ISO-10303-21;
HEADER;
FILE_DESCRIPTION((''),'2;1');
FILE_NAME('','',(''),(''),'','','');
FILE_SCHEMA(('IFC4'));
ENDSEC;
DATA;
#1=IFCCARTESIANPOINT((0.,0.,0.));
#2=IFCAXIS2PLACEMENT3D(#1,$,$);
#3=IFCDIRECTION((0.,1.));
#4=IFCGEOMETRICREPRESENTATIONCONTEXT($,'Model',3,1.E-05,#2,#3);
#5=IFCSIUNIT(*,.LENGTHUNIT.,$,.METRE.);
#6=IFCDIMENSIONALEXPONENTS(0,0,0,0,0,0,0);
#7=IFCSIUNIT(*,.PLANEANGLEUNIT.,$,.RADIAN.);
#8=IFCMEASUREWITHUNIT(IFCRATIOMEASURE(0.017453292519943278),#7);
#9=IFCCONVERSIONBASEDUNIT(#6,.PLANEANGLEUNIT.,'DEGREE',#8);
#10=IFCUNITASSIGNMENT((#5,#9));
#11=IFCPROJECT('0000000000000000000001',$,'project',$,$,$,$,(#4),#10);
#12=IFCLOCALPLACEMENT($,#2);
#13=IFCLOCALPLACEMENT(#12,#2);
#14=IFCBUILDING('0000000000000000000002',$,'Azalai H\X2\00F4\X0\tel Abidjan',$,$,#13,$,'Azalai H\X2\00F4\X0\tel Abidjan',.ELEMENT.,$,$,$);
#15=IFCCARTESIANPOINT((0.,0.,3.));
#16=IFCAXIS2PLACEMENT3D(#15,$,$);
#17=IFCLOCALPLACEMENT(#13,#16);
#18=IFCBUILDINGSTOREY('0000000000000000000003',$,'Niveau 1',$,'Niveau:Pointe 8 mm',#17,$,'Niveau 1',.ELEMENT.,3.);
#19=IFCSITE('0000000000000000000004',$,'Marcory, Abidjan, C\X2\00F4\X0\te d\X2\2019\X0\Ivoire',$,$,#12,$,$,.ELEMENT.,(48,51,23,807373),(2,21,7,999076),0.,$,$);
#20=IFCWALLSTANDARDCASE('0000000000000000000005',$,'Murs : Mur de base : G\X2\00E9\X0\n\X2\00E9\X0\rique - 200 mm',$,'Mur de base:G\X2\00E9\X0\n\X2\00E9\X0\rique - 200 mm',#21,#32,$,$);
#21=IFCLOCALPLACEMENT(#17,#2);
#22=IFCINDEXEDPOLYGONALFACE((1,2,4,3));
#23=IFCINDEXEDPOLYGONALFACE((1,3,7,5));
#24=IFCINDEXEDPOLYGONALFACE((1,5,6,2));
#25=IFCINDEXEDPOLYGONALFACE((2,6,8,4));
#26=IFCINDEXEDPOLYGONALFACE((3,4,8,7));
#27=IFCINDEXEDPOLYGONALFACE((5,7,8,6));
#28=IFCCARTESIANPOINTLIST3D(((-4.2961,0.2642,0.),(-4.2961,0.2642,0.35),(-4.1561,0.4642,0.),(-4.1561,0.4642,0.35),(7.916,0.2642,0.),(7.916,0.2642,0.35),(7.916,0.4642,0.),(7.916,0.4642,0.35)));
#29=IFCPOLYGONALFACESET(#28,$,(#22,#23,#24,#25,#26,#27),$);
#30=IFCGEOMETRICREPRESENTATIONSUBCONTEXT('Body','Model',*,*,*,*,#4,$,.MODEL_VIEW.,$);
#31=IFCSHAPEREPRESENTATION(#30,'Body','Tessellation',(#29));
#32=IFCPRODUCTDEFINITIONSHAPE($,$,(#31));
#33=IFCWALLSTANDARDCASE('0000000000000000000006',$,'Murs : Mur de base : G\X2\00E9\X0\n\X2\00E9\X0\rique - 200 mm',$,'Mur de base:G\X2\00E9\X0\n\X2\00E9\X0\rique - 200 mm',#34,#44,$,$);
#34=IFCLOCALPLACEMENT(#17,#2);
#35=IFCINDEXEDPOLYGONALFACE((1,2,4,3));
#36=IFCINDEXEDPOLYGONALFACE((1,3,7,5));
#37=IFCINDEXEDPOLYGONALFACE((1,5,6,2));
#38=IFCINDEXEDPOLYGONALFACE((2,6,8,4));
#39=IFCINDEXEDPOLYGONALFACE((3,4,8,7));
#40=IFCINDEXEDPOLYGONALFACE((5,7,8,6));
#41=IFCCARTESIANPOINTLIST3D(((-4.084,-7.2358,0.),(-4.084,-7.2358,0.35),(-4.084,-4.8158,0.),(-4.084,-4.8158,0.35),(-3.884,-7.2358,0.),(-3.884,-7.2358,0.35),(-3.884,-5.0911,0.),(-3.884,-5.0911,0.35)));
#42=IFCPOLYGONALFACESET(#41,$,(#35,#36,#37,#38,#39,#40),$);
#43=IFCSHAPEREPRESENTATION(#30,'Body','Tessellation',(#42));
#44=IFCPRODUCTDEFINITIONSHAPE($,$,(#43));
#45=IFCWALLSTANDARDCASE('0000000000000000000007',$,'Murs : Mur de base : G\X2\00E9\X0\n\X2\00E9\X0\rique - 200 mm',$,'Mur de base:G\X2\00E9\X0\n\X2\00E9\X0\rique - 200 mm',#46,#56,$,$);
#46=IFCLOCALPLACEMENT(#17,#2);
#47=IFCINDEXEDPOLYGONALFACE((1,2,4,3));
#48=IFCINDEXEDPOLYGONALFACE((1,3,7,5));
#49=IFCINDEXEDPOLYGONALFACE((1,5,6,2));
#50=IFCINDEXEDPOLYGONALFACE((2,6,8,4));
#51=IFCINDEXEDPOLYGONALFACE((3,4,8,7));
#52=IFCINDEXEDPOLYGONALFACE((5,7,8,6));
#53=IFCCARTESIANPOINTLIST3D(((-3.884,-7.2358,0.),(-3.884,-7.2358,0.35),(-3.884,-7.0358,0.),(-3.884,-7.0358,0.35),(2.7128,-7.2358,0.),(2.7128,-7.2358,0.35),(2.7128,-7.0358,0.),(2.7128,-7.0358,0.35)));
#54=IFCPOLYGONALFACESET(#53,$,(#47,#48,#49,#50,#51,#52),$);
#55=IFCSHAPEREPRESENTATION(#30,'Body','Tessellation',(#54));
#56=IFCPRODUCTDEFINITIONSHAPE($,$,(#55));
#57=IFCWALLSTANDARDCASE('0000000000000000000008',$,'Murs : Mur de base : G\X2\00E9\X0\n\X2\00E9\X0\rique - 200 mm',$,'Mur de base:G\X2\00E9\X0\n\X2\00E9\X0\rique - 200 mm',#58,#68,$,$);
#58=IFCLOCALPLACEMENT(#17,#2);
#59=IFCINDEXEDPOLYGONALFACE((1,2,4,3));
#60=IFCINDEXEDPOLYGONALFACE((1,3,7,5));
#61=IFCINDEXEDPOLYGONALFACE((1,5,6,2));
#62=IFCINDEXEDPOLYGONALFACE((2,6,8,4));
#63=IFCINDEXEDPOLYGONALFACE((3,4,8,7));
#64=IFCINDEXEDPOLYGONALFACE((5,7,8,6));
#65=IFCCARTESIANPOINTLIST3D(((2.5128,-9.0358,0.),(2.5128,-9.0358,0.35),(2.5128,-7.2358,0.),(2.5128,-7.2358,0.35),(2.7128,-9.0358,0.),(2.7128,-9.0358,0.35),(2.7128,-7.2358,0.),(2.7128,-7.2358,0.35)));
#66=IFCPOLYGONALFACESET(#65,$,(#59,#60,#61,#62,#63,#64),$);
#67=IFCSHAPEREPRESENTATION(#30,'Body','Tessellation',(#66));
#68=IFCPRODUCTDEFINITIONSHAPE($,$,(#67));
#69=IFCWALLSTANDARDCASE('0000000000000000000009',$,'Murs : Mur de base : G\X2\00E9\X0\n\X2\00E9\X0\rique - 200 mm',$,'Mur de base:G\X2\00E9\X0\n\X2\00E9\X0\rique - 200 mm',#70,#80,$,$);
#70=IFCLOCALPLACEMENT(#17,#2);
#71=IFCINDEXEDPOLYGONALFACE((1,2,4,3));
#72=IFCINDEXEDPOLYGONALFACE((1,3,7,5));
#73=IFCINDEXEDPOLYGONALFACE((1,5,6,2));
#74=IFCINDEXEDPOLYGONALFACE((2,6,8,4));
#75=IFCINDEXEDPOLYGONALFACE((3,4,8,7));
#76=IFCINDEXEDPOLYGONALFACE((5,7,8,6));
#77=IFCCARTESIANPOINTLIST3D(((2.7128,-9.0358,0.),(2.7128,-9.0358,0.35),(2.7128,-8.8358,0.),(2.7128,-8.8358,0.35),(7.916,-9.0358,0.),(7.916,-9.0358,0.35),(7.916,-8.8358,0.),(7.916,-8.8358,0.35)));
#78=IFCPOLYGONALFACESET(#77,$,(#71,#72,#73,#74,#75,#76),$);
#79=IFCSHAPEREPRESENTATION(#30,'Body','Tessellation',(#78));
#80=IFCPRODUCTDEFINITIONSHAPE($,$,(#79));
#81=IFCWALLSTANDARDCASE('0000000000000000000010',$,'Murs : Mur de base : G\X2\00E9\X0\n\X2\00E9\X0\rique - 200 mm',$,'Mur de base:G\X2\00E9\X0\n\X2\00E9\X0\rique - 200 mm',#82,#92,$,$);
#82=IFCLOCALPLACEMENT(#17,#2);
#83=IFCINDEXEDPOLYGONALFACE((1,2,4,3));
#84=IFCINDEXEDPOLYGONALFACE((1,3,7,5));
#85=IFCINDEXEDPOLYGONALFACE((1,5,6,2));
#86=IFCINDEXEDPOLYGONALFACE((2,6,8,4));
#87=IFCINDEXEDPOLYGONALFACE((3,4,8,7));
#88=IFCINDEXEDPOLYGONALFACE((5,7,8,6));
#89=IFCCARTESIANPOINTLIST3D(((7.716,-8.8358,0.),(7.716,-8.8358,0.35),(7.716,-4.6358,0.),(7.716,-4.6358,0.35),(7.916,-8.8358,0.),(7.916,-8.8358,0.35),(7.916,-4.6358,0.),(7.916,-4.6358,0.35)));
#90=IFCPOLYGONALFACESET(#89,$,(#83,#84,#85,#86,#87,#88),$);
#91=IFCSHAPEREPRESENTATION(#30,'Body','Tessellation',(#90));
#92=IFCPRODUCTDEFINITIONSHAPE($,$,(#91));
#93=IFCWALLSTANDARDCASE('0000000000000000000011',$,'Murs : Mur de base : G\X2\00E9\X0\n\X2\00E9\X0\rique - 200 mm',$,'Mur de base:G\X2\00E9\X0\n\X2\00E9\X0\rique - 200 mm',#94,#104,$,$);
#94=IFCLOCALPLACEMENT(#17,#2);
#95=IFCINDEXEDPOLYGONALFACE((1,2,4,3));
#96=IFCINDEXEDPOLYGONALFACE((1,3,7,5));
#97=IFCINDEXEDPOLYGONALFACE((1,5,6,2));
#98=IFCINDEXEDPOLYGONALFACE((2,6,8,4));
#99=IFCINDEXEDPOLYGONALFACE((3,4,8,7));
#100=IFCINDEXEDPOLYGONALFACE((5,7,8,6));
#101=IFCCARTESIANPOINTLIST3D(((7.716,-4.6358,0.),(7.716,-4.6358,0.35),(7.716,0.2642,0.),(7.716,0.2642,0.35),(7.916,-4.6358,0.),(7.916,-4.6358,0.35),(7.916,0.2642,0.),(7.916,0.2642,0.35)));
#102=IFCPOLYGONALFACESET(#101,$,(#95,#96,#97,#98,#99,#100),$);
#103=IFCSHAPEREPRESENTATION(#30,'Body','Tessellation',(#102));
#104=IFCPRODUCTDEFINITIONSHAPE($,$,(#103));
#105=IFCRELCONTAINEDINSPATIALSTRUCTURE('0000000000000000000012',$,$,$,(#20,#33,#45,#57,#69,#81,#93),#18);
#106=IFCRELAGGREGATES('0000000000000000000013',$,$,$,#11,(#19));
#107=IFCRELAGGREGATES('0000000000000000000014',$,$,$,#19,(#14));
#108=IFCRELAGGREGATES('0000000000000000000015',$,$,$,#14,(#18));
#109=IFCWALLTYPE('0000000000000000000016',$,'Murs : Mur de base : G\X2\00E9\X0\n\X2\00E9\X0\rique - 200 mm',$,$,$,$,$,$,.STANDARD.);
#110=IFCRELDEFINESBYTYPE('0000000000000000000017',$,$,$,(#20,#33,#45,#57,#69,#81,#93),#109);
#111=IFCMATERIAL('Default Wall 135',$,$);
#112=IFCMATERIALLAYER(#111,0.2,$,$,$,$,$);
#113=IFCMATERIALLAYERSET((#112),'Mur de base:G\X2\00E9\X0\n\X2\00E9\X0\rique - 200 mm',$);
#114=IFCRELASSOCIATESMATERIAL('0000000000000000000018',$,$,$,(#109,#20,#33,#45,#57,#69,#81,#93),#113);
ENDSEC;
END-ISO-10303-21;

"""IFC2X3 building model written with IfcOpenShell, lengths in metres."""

from ifc_helpers import new_model, entity, si_unit, converted_unit, direction, frame, frame_2d, origin, place, context, subcontext, project, spatial, polyline, rectangle, outline, extrude, clip, halfspace, material, layer, layer_set, layer_usage, type_object, element, save


model = new_model("IFC2X3")

# Units and contexts
model_context = context("Model", 3, precision=1e-05, world=origin(), true_north=direction((0.0, 1.0)))
body_context = subcontext(model_context, "Body", "Model", "MODEL_VIEW")
ifc_project = project(units=[si_unit("LENGTHUNIT", "METRE"), converted_unit("PLANEANGLEUNIT", "DEGREE", entity("IfcRatioMeasure", 0.017453292519943278), si_unit("PLANEANGLEUNIT", "RADIAN"), dimensions=[0, 0, 0, 0, 0, 0, 0])], contexts=[model_context])

# Site, building, storey
site_placement = place(None, origin())
site = spatial("IfcSite", under=ifc_project, at=site_placement, Name="Marcory, Abidjan, Côte d’Ivoire", CompositionType="ELEMENT", RefLatitude=(48, 51, 23, 807373), RefLongitude=(2, 21, 7, 999076), RefElevation=0.0)
building_placement = place(site_placement, origin())
building = spatial("IfcBuilding", under=site, at=building_placement, Name="Azalai Hôtel Abidjan", LongName="Azalai Hôtel Abidjan", CompositionType="ELEMENT")
storey_placement = place(building_placement, frame((0.0, 0.0, 3.0)))
storey = spatial("IfcBuildingStorey", under=building, at=storey_placement, Name="Niveau 1", ObjectType="Niveau:Pointe 8 mm", LongName="Niveau 1", CompositionType="ELEMENT", Elevation=3.0)

# Walls
ifc_material = material(Name="Default Wall 135")
ifc_layer = layer(ifc_material, 0.2)
ifc_layer_set = layer_set([ifc_layer], Name="Mur de base:Générique - 200 mm")
ifc_layer_usage = layer_usage(ifc_layer_set, "AXIS2", "NEGATIVE", 0.1)
wall_type = type_object("IfcWallType", Name="Murs : Mur de base : Générique - 200 mm", PredefinedType="STANDARD", material=ifc_layer_set)
wall_1_placement = place(storey_placement, frame((7.916, 0.3642, 0.0), z_axis=(0.0, 0.0, 1.0), x_axis=(-1.0, 0.0, 0.0)))
element("IfcWallStandardCase", 1, at=wall_1_placement, inside=storey, type_object=wall_type, material=ifc_layer_usage, Name="Murs : Mur de base : Générique - 200 mm", ObjectType="Mur de base:Générique - 200 mm", context=body_context, shape_type="Clipping", body=[
    clip(extrude(outline(polyline([(12.0721, -0.1), (12.2121, 0.1), (11.9679, 0.1), (0.2, 0.1), (0.0, 0.1), (0.0, -0.1), (12.0721, -0.1)])), origin(), (0.0, 0.0, 1.0), 0.35), halfspace(frame((0.0, 0.0, -3.0)), True)),
])
wall_2_placement = place(storey_placement, frame((-3.984, -4.8158, 0.0), z_axis=(0.0, 0.0, 1.0), x_axis=(0.0, -1.0, 0.0)))
element("IfcWallStandardCase", 2, at=wall_2_placement, inside=storey, type_object=wall_type, material=ifc_layer_usage, Name="Murs : Mur de base : Générique - 200 mm", ObjectType="Mur de base:Générique - 200 mm", context=body_context, shape_type="Clipping", body=[
    clip(extrude(outline(polyline([(2.4199, -0.1), (2.4199, 0.1), (2.2199, 0.1), (0.2753, 0.1), (0.0, -0.1), (2.4199, -0.1)])), origin(), (0.0, 0.0, 1.0), 0.35), halfspace(frame((0.0, 0.0, -3.0)), True)),
])
wall_3_placement = place(storey_placement, frame((-3.884, -7.1358, 0.0)))
element("IfcWallStandardCase", 3, at=wall_3_placement, inside=storey, type_object=wall_type, material=ifc_layer_usage, Name="Murs : Mur de base : Générique - 200 mm", ObjectType="Mur de base:Générique - 200 mm", context=body_context, shape_type="Clipping", body=[
    clip(extrude(rectangle(XDim=6.5968, YDim=0.2, at=frame_2d((3.2984, 0.0), x_axis=(-1.0, 0.0))), origin(), (0.0, 0.0, 1.0), 0.35), halfspace(frame((0.0, 0.0, -3.0)), True)),
])
wall_4_placement = place(storey_placement, frame((2.6128, -7.2358, 0.0), z_axis=(0.0, 0.0, 1.0), x_axis=(0.0, -1.0, 0.0)))
element("IfcWallStandardCase", 4, at=wall_4_placement, inside=storey, type_object=wall_type, material=ifc_layer_usage, Name="Murs : Mur de base : Générique - 200 mm", ObjectType="Mur de base:Générique - 200 mm", context=body_context, shape_type="Clipping", body=[
    clip(extrude(rectangle(XDim=1.8, YDim=0.2, at=frame_2d((0.9, 0.0), x_axis=(-1.0, 0.0))), origin(), (0.0, 0.0, 1.0), 0.35), halfspace(frame((0.0, 0.0, -3.0)), True)),
])
wall_5_placement = place(storey_placement, frame((2.7128, -8.9358, 0.0)))
element("IfcWallStandardCase", 5, at=wall_5_placement, inside=storey, type_object=wall_type, material=ifc_layer_usage, Name="Murs : Mur de base : Générique - 200 mm", ObjectType="Mur de base:Générique - 200 mm", context=body_context, shape_type="Clipping", body=[
    clip(extrude(rectangle(XDim=5.2032, YDim=0.2, at=frame_2d((2.6016, 0.0), x_axis=(-1.0, 0.0))), origin(), (0.0, 0.0, 1.0), 0.35), halfspace(frame((0.0, 0.0, -3.0)), True)),
])
wall_6_placement = place(storey_placement, frame((7.816, -8.8358, 0.0), z_axis=(0.0, 0.0, 1.0), x_axis=(0.0, 1.0, 0.0)))
element("IfcWallStandardCase", 6, at=wall_6_placement, inside=storey, type_object=wall_type, material=ifc_layer_usage, Name="Murs : Mur de base : Générique - 200 mm", ObjectType="Mur de base:Générique - 200 mm", context=body_context, shape_type="Clipping", body=[
    clip(extrude(rectangle(XDim=4.2, YDim=0.2, at=frame_2d((2.1, 0.0), x_axis=(-1.0, 0.0))), origin(), (0.0, 0.0, 1.0), 0.35), halfspace(frame((0.0, 0.0, -3.0)), True)),
])
wall_7_placement = place(storey_placement, frame((7.816, -4.6358, 0.0), z_axis=(0.0, 0.0, 1.0), x_axis=(0.0, 1.0, 0.0)))
element("IfcWallStandardCase", 7, at=wall_7_placement, inside=storey, type_object=wall_type, material=ifc_layer_usage, Name="Murs : Mur de base : Générique - 200 mm", ObjectType="Mur de base:Générique - 200 mm", context=body_context, shape_type="Clipping", body=[
    clip(extrude(rectangle(XDim=4.9, YDim=0.2, at=frame_2d((2.45, 0.0), x_axis=(-1.0, 0.0))), origin(), (0.0, 0.0, 1.0), 0.35), halfspace(frame((0.0, 0.0, -3.0)), True)),
])

save(model, "model.ifc")
